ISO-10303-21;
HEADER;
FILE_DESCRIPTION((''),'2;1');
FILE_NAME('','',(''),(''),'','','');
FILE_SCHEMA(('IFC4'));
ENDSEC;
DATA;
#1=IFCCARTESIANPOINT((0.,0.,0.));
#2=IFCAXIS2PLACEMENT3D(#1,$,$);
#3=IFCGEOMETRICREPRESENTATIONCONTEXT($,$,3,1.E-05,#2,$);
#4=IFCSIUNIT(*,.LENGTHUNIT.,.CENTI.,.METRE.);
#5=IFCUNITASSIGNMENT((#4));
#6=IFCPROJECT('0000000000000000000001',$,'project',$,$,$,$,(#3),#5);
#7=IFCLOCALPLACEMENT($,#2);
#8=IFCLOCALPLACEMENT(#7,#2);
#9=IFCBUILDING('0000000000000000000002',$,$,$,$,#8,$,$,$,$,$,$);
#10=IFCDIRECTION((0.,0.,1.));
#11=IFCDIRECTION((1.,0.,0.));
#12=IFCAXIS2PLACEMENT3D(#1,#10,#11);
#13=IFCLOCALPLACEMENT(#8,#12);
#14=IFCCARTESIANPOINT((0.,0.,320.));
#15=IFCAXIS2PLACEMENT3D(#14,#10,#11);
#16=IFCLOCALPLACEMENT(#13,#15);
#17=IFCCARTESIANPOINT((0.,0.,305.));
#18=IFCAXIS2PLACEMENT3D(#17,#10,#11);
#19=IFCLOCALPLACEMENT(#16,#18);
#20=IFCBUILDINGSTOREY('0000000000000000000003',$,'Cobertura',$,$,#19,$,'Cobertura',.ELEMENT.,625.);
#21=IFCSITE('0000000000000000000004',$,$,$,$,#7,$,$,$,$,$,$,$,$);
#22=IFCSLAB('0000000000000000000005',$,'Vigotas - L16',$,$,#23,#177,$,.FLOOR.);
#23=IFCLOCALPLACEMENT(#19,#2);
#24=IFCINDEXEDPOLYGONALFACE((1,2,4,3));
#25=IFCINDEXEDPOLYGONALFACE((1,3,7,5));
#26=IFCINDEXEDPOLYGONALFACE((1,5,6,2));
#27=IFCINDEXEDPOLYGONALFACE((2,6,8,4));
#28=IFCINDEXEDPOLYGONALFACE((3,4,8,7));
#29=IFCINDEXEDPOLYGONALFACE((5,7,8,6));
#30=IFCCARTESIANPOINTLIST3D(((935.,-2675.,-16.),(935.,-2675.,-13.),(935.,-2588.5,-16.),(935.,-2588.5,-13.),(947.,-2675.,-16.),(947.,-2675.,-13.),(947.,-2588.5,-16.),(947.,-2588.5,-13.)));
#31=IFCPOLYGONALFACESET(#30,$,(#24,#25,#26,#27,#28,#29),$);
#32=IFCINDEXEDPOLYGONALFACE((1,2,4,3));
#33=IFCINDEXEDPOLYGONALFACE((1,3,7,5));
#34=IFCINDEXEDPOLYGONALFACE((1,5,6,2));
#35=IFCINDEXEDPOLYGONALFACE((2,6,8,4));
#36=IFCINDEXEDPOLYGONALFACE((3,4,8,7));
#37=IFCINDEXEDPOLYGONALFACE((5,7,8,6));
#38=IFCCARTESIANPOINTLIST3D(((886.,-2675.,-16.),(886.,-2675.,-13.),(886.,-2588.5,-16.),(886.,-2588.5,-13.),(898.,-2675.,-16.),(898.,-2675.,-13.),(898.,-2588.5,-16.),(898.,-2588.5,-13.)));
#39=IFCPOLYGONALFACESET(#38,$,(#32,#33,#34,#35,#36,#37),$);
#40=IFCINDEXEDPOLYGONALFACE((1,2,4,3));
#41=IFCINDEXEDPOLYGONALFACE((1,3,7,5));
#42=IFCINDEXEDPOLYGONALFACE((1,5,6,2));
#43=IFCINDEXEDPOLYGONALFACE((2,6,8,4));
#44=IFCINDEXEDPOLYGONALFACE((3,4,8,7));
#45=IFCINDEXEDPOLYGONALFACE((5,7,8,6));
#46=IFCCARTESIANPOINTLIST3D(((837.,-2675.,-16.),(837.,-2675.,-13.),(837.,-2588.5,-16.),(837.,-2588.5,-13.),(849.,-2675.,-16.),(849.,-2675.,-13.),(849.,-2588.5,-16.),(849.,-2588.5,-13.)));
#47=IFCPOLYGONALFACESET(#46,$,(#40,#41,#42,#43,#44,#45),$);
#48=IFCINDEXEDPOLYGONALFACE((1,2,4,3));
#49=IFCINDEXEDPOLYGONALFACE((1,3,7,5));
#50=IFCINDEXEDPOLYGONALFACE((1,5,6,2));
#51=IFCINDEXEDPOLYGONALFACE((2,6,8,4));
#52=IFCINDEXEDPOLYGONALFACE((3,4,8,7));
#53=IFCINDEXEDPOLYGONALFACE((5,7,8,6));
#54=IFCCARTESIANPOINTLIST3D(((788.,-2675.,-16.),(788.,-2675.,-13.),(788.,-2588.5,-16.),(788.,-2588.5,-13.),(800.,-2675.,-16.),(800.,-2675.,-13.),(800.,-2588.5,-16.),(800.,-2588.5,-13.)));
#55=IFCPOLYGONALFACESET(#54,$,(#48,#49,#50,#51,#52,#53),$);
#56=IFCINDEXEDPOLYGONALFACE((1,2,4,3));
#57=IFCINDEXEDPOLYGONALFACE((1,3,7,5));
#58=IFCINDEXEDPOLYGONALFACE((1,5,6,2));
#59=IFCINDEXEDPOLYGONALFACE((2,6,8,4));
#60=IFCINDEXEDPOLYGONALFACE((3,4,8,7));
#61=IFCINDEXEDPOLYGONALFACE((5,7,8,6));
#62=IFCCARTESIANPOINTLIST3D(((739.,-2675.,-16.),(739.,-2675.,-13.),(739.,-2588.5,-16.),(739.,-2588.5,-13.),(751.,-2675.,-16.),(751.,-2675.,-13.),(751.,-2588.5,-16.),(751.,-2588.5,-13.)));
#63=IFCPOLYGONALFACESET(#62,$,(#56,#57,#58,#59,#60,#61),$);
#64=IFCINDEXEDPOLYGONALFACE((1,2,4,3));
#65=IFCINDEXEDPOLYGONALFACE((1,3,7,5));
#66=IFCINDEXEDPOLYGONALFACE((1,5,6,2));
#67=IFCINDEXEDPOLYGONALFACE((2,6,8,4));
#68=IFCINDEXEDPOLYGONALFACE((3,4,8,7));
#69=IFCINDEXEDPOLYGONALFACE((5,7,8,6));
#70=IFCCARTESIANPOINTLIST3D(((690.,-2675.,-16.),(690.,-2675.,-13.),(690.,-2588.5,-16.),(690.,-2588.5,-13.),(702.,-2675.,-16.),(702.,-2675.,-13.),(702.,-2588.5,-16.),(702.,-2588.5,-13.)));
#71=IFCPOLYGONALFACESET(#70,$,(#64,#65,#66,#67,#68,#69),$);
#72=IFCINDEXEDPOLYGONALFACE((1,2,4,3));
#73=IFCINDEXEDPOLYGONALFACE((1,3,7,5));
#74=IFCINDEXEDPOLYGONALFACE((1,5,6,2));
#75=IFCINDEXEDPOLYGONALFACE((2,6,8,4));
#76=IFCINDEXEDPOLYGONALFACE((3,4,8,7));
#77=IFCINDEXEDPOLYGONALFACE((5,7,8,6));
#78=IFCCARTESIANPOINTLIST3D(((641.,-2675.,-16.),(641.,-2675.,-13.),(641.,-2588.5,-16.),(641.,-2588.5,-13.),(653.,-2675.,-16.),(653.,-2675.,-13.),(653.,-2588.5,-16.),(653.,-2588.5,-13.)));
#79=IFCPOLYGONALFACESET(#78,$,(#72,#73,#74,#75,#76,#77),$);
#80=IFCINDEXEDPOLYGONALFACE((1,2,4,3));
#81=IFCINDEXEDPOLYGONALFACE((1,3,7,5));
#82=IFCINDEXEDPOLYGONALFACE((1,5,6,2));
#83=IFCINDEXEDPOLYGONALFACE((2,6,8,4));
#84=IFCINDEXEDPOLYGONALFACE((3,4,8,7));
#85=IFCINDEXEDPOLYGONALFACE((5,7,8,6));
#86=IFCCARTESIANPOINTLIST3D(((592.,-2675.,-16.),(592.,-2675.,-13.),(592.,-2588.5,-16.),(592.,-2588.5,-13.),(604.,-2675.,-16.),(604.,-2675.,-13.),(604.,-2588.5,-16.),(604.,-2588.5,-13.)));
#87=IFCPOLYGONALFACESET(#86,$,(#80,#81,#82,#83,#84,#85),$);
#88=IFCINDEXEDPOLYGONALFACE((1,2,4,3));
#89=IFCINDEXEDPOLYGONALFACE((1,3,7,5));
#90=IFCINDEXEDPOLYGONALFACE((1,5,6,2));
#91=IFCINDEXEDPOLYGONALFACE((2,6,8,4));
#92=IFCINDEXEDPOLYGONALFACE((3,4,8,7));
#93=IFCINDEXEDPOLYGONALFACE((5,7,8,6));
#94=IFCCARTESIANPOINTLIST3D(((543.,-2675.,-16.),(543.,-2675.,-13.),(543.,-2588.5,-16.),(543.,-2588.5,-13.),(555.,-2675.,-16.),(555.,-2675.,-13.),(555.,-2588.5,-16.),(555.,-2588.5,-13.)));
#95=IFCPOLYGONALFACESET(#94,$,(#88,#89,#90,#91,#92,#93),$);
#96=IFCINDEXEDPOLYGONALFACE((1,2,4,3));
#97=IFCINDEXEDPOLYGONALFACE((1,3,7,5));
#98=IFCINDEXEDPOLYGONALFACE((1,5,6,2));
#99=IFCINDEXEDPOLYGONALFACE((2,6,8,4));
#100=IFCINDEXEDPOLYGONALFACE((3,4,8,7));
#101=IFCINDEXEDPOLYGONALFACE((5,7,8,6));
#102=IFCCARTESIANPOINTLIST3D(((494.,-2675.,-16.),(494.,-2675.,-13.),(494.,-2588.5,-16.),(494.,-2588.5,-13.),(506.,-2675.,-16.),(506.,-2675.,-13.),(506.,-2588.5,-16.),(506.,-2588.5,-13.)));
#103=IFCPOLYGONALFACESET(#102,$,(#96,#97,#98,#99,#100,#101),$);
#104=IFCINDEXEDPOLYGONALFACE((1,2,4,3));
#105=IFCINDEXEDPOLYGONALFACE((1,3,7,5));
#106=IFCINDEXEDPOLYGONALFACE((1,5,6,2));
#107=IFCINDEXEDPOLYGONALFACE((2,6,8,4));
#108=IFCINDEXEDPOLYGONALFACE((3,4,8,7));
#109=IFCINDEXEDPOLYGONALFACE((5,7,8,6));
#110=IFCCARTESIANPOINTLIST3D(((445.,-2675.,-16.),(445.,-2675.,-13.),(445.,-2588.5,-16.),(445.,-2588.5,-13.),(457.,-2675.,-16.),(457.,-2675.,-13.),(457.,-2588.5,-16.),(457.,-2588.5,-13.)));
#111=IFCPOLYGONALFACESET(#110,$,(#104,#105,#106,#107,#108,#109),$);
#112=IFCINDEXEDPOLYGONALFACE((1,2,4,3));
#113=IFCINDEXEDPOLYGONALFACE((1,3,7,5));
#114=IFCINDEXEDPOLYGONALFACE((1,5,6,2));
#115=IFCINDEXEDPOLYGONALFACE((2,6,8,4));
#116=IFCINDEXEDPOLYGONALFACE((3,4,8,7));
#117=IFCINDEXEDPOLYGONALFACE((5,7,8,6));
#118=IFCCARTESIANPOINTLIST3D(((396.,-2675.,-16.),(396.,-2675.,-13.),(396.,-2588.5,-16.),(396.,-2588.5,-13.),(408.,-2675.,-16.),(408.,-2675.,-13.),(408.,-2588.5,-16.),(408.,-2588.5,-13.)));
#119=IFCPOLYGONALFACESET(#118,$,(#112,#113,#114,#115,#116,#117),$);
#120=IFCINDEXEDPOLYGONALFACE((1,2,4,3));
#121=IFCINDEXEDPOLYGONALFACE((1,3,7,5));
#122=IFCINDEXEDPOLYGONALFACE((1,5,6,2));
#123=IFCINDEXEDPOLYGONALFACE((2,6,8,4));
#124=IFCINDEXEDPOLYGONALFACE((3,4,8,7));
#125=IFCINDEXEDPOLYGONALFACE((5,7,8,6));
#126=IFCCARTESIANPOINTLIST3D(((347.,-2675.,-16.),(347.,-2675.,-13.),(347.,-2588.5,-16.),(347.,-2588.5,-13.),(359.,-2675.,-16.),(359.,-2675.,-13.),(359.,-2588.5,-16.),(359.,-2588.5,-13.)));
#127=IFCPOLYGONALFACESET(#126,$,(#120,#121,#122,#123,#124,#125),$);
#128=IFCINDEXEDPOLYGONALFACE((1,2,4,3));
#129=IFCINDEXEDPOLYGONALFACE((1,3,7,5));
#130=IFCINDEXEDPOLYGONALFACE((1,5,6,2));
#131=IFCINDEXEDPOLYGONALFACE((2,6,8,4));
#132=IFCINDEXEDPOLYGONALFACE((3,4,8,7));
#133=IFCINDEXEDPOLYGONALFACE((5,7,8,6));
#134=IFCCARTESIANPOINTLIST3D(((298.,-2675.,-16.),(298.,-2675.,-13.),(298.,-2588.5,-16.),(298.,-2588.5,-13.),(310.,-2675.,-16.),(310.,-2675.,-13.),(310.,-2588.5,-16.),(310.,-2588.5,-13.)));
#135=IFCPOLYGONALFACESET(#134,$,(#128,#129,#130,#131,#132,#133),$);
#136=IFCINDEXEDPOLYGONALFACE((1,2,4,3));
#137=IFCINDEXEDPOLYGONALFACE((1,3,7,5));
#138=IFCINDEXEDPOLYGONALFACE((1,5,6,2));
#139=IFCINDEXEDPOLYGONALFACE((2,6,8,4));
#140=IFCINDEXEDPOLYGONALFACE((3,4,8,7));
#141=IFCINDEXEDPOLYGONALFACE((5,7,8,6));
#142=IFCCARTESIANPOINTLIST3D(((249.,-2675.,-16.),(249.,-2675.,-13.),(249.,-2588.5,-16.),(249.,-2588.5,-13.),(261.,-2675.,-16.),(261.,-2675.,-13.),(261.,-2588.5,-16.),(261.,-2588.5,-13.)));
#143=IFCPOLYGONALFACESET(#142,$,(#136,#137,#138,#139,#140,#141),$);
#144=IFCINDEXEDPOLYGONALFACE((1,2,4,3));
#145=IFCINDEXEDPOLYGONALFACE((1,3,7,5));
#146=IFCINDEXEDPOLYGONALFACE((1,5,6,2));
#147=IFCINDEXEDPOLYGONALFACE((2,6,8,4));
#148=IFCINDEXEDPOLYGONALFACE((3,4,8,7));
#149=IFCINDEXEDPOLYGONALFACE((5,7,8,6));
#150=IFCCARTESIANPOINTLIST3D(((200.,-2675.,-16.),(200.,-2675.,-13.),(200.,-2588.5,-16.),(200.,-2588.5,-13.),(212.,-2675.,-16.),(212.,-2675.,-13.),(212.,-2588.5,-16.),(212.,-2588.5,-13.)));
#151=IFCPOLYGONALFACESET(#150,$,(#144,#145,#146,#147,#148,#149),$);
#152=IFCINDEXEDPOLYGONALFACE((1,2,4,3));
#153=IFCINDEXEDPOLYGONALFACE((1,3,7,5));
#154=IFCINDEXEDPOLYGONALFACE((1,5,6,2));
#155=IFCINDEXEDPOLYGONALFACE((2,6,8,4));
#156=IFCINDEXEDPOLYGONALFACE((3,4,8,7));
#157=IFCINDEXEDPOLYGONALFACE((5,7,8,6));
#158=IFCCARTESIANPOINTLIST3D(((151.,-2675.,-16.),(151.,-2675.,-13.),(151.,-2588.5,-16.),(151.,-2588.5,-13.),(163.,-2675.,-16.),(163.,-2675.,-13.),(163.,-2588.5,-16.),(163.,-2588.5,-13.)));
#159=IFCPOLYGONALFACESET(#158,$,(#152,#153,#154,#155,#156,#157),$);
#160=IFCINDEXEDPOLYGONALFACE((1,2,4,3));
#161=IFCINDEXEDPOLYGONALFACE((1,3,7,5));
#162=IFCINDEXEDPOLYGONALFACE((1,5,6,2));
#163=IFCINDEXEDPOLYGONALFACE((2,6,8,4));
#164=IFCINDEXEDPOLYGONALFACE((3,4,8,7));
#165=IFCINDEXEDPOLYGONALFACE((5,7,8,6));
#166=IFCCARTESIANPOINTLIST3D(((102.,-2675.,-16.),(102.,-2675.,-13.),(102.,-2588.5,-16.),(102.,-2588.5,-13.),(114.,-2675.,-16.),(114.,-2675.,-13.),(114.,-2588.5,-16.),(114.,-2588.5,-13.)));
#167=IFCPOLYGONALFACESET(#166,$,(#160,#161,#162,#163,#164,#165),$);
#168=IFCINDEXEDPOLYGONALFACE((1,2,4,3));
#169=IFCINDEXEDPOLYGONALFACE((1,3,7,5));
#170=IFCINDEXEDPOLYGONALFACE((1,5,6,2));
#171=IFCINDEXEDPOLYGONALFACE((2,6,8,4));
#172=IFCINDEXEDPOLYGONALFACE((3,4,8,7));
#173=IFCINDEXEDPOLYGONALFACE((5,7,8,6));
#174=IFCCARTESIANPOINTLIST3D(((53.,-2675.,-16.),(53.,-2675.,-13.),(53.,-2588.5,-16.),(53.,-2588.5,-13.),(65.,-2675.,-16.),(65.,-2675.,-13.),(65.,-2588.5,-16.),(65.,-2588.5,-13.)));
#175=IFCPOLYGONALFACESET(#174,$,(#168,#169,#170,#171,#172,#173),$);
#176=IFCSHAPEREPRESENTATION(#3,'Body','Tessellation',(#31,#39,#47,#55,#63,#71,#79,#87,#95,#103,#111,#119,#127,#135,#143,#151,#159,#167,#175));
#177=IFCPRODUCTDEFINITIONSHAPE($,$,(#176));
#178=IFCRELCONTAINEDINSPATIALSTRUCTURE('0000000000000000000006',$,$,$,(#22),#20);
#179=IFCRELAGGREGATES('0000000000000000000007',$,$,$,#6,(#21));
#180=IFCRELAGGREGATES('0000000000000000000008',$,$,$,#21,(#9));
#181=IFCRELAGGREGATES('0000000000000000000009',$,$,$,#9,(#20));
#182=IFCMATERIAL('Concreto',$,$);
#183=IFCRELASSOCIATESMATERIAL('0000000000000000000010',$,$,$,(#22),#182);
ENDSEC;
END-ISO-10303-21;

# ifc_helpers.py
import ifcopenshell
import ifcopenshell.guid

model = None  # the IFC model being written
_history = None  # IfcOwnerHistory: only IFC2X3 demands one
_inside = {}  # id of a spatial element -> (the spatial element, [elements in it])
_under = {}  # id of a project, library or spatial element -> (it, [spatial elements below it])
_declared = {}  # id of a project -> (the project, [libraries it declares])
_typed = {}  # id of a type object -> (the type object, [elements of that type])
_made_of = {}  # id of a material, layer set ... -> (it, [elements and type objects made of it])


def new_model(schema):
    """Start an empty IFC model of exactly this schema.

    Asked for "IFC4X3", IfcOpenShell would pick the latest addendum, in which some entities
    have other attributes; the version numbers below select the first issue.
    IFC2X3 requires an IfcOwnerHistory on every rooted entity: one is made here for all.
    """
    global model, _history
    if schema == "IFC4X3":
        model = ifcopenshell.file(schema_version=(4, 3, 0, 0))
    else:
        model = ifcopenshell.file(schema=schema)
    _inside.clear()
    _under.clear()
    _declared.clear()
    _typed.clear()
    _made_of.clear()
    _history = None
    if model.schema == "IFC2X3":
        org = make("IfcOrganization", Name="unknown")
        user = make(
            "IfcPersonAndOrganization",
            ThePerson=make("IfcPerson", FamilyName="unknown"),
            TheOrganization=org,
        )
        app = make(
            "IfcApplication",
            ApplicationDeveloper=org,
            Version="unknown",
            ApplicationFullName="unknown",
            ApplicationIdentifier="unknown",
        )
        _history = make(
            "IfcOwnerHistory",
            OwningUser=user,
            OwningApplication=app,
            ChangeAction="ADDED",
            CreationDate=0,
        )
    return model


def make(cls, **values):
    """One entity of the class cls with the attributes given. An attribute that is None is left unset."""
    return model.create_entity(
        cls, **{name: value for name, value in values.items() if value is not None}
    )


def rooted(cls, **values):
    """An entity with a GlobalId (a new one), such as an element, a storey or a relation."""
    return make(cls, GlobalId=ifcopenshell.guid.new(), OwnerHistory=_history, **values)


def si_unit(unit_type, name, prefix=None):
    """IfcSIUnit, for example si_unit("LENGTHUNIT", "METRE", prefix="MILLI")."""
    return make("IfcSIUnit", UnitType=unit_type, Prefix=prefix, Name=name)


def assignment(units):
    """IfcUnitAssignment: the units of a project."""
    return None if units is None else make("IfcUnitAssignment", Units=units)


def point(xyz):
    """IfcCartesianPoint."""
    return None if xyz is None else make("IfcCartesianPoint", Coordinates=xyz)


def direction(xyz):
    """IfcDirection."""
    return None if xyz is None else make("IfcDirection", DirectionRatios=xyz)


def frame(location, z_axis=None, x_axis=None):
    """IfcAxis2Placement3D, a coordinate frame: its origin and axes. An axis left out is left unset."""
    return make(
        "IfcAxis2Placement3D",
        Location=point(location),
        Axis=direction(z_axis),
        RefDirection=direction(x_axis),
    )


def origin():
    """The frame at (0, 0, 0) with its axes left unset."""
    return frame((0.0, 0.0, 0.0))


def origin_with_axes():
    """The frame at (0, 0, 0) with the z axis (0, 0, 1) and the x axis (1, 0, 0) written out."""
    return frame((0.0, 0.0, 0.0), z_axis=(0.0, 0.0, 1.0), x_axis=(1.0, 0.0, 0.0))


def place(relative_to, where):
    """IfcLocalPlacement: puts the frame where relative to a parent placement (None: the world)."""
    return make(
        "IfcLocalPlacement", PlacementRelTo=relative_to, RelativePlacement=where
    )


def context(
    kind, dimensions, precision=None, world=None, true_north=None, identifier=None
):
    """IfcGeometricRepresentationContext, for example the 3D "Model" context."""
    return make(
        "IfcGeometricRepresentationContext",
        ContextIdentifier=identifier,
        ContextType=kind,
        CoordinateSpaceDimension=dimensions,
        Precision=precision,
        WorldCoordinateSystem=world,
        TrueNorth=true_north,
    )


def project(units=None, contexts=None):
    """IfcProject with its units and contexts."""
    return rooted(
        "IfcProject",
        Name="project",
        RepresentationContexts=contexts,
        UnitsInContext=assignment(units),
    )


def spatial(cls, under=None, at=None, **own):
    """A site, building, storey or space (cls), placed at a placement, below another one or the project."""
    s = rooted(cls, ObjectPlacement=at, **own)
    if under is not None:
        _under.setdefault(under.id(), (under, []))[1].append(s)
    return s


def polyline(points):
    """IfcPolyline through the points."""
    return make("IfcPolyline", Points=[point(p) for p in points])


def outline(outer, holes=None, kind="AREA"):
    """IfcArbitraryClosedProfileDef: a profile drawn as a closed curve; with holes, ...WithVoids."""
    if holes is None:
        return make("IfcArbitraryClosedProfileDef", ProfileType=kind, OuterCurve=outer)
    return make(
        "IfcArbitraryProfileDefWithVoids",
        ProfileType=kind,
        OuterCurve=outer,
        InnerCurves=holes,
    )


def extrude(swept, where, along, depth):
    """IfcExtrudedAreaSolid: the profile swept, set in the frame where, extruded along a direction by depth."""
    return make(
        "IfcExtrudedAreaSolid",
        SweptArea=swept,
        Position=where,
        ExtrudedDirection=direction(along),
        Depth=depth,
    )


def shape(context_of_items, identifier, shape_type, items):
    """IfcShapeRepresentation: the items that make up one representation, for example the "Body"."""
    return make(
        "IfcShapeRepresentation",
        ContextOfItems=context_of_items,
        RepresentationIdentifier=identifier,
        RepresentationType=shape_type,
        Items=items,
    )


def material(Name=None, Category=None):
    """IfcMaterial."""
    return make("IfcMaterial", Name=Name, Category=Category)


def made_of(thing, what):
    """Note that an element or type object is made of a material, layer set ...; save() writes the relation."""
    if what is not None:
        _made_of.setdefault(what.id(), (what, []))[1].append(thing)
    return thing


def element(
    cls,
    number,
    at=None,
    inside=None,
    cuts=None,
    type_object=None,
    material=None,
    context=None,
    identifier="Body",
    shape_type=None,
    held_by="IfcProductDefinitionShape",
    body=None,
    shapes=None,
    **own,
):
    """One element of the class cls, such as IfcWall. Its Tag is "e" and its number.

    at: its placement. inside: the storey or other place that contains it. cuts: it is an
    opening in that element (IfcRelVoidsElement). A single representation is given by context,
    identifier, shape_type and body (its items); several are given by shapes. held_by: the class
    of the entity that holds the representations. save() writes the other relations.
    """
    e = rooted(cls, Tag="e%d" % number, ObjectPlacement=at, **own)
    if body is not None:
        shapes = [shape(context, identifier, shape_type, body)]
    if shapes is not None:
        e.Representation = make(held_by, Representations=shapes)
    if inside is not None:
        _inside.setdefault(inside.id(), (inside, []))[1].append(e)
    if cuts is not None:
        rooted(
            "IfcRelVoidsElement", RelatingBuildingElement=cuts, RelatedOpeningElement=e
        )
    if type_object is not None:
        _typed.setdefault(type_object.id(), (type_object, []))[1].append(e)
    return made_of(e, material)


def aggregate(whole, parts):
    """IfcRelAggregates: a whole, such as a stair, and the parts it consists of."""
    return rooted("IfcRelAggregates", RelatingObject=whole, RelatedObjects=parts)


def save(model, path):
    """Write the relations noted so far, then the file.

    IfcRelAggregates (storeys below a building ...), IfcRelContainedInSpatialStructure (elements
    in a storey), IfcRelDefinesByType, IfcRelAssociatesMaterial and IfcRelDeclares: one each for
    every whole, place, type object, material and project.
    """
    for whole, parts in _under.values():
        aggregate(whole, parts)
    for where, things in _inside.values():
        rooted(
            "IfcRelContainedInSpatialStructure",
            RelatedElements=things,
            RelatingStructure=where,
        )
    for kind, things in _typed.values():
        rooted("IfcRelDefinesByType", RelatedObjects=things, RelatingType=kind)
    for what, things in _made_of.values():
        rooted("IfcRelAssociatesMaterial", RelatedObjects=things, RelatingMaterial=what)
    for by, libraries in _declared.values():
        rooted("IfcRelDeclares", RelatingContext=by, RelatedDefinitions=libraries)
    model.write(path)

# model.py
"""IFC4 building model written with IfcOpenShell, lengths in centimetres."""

from ifc_helpers import new_model, si_unit, frame, origin, origin_with_axes, place, context, project, spatial, polyline, outline, extrude, material, element, save


model = new_model("IFC4")

# Units and contexts
context_of_model = context(None, 3, precision=1e-05, world=origin())
ifc_project = project(units=[si_unit("LENGTHUNIT", "METRE", prefix="CENTI")], contexts=[context_of_model])

# Site, building, storey
site_placement = place(None, origin())
site = spatial("IfcSite", under=ifc_project, at=site_placement)
building_placement = place(site_placement, origin())
building = spatial("IfcBuilding", under=site, at=building_placement)
placement_1 = place(building_placement, origin_with_axes())
placement_2 = place(placement_1, frame((0.0, 0.0, 320.0), z_axis=(0.0, 0.0, 1.0), x_axis=(1.0, 0.0, 0.0)))
storey_placement = place(placement_2, frame((0.0, 0.0, 305.0), z_axis=(0.0, 0.0, 1.0), x_axis=(1.0, 0.0, 0.0)))
storey = spatial("IfcBuildingStorey", under=building, at=storey_placement, Name="Cobertura", LongName="Cobertura", CompositionType="ELEMENT", Elevation=625.0)

# Shared definitions
ifc_material = material(Name="Concreto")

# Slab
slab_1_placement = place(storey_placement, frame((500.0, -2631.75, -13.0), z_axis=(0.0, 0.0, 1.0), x_axis=(1.0, 0.0, 0.0)))
element("IfcSlab", 1, at=slab_1_placement, inside=storey, material=ifc_material, Name="Vigotas - L16", PredefinedType="FLOOR", context=context_of_model, shape_type="SolidModel", body=[
    extrude(outline(polyline([(6.0, 1.5), (-6.0, 1.5), (-6.0, -1.5), (6.0, -1.5), (6.0, 1.5), (6.0, 1.5)])), frame((441.0, -43.25, -1.5), z_axis=(0.0, 1.0, 0.0), x_axis=(1.0, 0.0, 0.0)), (0.0, 0.0, 1.0), 86.5),
    extrude(outline(polyline([(6.0, 1.5), (-6.0, 1.5), (-6.0, -1.5), (6.0, -1.5), (6.0, 1.5), (6.0, 1.5)])), frame((392.0, -43.25, -1.5), z_axis=(0.0, 1.0, 0.0), x_axis=(1.0, 0.0, 0.0)), (0.0, 0.0, 1.0), 86.5),
    extrude(outline(polyline([(6.0, 1.5), (-6.0, 1.5), (-6.0, -1.5), (6.0, -1.5), (6.0, 1.5), (6.0, 1.5)])), frame((343.0, -43.25, -1.5), z_axis=(0.0, 1.0, 0.0), x_axis=(1.0, 0.0, 0.0)), (0.0, 0.0, 1.0), 86.5),
    extrude(outline(polyline([(6.0, 1.5), (-6.0, 1.5), (-6.0, -1.5), (6.0, -1.5), (6.0, 1.5), (6.0, 1.5)])), frame((294.0, -43.25, -1.5), z_axis=(0.0, 1.0, 0.0), x_axis=(1.0, 0.0, 0.0)), (0.0, 0.0, 1.0), 86.5),
    extrude(outline(polyline([(6.0, 1.5), (-6.0, 1.5), (-6.0, -1.5), (6.0, -1.5), (6.0, 1.5), (6.0, 1.5)])), frame((245.0, -43.25, -1.5), z_axis=(0.0, 1.0, 0.0), x_axis=(1.0, 0.0, 0.0)), (0.0, 0.0, 1.0), 86.5),
    extrude(outline(polyline([(6.0, 1.5), (-6.0, 1.5), (-6.0, -1.5), (6.0, -1.5), (6.0, 1.5), (6.0, 1.5)])), frame((196.0, -43.25, -1.5), z_axis=(0.0, 1.0, 0.0), x_axis=(1.0, 0.0, 0.0)), (0.0, 0.0, 1.0), 86.5),
    extrude(outline(polyline([(6.0, 1.5), (-6.0, 1.5), (-6.0, -1.5), (6.0, -1.5), (6.0, 1.5), (6.0, 1.5)])), frame((147.0, -43.25, -1.5), z_axis=(0.0, 1.0, 0.0), x_axis=(1.0, 0.0, 0.0)), (0.0, 0.0, 1.0), 86.5),
    extrude(outline(polyline([(6.0, 1.5), (-6.0, 1.5), (-6.0, -1.5), (6.0, -1.5), (6.0, 1.5), (6.0, 1.5)])), frame((98.0, -43.25, -1.5), z_axis=(0.0, 1.0, 0.0), x_axis=(1.0, 0.0, 0.0)), (0.0, 0.0, 1.0), 86.5),
    extrude(outline(polyline([(6.0, 1.5), (-6.0, 1.5), (-6.0, -1.5), (6.0, -1.5), (6.0, 1.5), (6.0, 1.5)])), frame((49.0, -43.25, -1.5), z_axis=(0.0, 1.0, 0.0), x_axis=(1.0, 0.0, 0.0)), (0.0, 0.0, 1.0), 86.5),
    extrude(outline(polyline([(6.0, 1.5), (-6.0, 1.5), (-6.0, -1.5), (6.0, -1.5), (6.0, 1.5), (6.0, 1.5)])), frame((0.0, -43.25, -1.5), z_axis=(0.0, 1.0, 0.0), x_axis=(1.0, 0.0, 0.0)), (0.0, 0.0, 1.0), 86.5),
    extrude(outline(polyline([(6.0, 1.5), (-6.0, 1.5), (-6.0, -1.5), (6.0, -1.5), (6.0, 1.5), (6.0, 1.5)])), frame((-49.0, -43.25, -1.5), z_axis=(0.0, 1.0, 0.0), x_axis=(1.0, 0.0, 0.0)), (0.0, 0.0, 1.0), 86.5),
    extrude(outline(polyline([(6.0, 1.5), (-6.0, 1.5), (-6.0, -1.5), (6.0, -1.5), (6.0, 1.5), (6.0, 1.5)])), frame((-98.0, -43.25, -1.5), z_axis=(0.0, 1.0, 0.0), x_axis=(1.0, 0.0, 0.0)), (0.0, 0.0, 1.0), 86.5),
    extrude(outline(polyline([(6.0, 1.5), (-6.0, 1.5), (-6.0, -1.5), (6.0, -1.5), (6.0, 1.5), (6.0, 1.5)])), frame((-147.0, -43.25, -1.5), z_axis=(0.0, 1.0, 0.0), x_axis=(1.0, 0.0, 0.0)), (0.0, 0.0, 1.0), 86.5),
    extrude(outline(polyline([(6.0, 1.5), (-6.0, 1.5), (-6.0, -1.5), (6.0, -1.5), (6.0, 1.5), (6.0, 1.5)])), frame((-196.0, -43.25, -1.5), z_axis=(0.0, 1.0, 0.0), x_axis=(1.0, 0.0, 0.0)), (0.0, 0.0, 1.0), 86.5),
    extrude(outline(polyline([(6.0, 1.5), (-6.0, 1.5), (-6.0, -1.5), (6.0, -1.5), (6.0, 1.5), (6.0, 1.5)])), frame((-245.0, -43.25, -1.5), z_axis=(0.0, 1.0, 0.0), x_axis=(1.0, 0.0, 0.0)), (0.0, 0.0, 1.0), 86.5),
    extrude(outline(polyline([(6.0, 1.5), (-6.0, 1.5), (-6.0, -1.5), (6.0, -1.5), (6.0, 1.5), (6.0, 1.5)])), frame((-294.0, -43.25, -1.5), z_axis=(0.0, 1.0, 0.0), x_axis=(1.0, 0.0, 0.0)), (0.0, 0.0, 1.0), 86.5),
    extrude(outline(polyline([(6.0, 1.5), (-6.0, 1.5), (-6.0, -1.5), (6.0, -1.5), (6.0, 1.5), (6.0, 1.5)])), frame((-343.0, -43.25, -1.5), z_axis=(0.0, 1.0, 0.0), x_axis=(1.0, 0.0, 0.0)), (0.0, 0.0, 1.0), 86.5),
    extrude(outline(polyline([(6.0, 1.5), (-6.0, 1.5), (-6.0, -1.5), (6.0, -1.5), (6.0, 1.5), (6.0, 1.5)])), frame((-392.0, -43.25, -1.5), z_axis=(0.0, 1.0, 0.0), x_axis=(1.0, 0.0, 0.0)), (0.0, 0.0, 1.0), 86.5),
    extrude(outline(polyline([(6.0, 1.5), (-6.0, 1.5), (-6.0, -1.5), (6.0, -1.5), (6.0, 1.5), (6.0, 1.5)])), frame((-441.0, -43.25, -1.5), z_axis=(0.0, 1.0, 0.0), x_axis=(1.0, 0.0, 0.0)), (0.0, 0.0, 1.0), 86.5),
])

save(model, "model.ifc")
